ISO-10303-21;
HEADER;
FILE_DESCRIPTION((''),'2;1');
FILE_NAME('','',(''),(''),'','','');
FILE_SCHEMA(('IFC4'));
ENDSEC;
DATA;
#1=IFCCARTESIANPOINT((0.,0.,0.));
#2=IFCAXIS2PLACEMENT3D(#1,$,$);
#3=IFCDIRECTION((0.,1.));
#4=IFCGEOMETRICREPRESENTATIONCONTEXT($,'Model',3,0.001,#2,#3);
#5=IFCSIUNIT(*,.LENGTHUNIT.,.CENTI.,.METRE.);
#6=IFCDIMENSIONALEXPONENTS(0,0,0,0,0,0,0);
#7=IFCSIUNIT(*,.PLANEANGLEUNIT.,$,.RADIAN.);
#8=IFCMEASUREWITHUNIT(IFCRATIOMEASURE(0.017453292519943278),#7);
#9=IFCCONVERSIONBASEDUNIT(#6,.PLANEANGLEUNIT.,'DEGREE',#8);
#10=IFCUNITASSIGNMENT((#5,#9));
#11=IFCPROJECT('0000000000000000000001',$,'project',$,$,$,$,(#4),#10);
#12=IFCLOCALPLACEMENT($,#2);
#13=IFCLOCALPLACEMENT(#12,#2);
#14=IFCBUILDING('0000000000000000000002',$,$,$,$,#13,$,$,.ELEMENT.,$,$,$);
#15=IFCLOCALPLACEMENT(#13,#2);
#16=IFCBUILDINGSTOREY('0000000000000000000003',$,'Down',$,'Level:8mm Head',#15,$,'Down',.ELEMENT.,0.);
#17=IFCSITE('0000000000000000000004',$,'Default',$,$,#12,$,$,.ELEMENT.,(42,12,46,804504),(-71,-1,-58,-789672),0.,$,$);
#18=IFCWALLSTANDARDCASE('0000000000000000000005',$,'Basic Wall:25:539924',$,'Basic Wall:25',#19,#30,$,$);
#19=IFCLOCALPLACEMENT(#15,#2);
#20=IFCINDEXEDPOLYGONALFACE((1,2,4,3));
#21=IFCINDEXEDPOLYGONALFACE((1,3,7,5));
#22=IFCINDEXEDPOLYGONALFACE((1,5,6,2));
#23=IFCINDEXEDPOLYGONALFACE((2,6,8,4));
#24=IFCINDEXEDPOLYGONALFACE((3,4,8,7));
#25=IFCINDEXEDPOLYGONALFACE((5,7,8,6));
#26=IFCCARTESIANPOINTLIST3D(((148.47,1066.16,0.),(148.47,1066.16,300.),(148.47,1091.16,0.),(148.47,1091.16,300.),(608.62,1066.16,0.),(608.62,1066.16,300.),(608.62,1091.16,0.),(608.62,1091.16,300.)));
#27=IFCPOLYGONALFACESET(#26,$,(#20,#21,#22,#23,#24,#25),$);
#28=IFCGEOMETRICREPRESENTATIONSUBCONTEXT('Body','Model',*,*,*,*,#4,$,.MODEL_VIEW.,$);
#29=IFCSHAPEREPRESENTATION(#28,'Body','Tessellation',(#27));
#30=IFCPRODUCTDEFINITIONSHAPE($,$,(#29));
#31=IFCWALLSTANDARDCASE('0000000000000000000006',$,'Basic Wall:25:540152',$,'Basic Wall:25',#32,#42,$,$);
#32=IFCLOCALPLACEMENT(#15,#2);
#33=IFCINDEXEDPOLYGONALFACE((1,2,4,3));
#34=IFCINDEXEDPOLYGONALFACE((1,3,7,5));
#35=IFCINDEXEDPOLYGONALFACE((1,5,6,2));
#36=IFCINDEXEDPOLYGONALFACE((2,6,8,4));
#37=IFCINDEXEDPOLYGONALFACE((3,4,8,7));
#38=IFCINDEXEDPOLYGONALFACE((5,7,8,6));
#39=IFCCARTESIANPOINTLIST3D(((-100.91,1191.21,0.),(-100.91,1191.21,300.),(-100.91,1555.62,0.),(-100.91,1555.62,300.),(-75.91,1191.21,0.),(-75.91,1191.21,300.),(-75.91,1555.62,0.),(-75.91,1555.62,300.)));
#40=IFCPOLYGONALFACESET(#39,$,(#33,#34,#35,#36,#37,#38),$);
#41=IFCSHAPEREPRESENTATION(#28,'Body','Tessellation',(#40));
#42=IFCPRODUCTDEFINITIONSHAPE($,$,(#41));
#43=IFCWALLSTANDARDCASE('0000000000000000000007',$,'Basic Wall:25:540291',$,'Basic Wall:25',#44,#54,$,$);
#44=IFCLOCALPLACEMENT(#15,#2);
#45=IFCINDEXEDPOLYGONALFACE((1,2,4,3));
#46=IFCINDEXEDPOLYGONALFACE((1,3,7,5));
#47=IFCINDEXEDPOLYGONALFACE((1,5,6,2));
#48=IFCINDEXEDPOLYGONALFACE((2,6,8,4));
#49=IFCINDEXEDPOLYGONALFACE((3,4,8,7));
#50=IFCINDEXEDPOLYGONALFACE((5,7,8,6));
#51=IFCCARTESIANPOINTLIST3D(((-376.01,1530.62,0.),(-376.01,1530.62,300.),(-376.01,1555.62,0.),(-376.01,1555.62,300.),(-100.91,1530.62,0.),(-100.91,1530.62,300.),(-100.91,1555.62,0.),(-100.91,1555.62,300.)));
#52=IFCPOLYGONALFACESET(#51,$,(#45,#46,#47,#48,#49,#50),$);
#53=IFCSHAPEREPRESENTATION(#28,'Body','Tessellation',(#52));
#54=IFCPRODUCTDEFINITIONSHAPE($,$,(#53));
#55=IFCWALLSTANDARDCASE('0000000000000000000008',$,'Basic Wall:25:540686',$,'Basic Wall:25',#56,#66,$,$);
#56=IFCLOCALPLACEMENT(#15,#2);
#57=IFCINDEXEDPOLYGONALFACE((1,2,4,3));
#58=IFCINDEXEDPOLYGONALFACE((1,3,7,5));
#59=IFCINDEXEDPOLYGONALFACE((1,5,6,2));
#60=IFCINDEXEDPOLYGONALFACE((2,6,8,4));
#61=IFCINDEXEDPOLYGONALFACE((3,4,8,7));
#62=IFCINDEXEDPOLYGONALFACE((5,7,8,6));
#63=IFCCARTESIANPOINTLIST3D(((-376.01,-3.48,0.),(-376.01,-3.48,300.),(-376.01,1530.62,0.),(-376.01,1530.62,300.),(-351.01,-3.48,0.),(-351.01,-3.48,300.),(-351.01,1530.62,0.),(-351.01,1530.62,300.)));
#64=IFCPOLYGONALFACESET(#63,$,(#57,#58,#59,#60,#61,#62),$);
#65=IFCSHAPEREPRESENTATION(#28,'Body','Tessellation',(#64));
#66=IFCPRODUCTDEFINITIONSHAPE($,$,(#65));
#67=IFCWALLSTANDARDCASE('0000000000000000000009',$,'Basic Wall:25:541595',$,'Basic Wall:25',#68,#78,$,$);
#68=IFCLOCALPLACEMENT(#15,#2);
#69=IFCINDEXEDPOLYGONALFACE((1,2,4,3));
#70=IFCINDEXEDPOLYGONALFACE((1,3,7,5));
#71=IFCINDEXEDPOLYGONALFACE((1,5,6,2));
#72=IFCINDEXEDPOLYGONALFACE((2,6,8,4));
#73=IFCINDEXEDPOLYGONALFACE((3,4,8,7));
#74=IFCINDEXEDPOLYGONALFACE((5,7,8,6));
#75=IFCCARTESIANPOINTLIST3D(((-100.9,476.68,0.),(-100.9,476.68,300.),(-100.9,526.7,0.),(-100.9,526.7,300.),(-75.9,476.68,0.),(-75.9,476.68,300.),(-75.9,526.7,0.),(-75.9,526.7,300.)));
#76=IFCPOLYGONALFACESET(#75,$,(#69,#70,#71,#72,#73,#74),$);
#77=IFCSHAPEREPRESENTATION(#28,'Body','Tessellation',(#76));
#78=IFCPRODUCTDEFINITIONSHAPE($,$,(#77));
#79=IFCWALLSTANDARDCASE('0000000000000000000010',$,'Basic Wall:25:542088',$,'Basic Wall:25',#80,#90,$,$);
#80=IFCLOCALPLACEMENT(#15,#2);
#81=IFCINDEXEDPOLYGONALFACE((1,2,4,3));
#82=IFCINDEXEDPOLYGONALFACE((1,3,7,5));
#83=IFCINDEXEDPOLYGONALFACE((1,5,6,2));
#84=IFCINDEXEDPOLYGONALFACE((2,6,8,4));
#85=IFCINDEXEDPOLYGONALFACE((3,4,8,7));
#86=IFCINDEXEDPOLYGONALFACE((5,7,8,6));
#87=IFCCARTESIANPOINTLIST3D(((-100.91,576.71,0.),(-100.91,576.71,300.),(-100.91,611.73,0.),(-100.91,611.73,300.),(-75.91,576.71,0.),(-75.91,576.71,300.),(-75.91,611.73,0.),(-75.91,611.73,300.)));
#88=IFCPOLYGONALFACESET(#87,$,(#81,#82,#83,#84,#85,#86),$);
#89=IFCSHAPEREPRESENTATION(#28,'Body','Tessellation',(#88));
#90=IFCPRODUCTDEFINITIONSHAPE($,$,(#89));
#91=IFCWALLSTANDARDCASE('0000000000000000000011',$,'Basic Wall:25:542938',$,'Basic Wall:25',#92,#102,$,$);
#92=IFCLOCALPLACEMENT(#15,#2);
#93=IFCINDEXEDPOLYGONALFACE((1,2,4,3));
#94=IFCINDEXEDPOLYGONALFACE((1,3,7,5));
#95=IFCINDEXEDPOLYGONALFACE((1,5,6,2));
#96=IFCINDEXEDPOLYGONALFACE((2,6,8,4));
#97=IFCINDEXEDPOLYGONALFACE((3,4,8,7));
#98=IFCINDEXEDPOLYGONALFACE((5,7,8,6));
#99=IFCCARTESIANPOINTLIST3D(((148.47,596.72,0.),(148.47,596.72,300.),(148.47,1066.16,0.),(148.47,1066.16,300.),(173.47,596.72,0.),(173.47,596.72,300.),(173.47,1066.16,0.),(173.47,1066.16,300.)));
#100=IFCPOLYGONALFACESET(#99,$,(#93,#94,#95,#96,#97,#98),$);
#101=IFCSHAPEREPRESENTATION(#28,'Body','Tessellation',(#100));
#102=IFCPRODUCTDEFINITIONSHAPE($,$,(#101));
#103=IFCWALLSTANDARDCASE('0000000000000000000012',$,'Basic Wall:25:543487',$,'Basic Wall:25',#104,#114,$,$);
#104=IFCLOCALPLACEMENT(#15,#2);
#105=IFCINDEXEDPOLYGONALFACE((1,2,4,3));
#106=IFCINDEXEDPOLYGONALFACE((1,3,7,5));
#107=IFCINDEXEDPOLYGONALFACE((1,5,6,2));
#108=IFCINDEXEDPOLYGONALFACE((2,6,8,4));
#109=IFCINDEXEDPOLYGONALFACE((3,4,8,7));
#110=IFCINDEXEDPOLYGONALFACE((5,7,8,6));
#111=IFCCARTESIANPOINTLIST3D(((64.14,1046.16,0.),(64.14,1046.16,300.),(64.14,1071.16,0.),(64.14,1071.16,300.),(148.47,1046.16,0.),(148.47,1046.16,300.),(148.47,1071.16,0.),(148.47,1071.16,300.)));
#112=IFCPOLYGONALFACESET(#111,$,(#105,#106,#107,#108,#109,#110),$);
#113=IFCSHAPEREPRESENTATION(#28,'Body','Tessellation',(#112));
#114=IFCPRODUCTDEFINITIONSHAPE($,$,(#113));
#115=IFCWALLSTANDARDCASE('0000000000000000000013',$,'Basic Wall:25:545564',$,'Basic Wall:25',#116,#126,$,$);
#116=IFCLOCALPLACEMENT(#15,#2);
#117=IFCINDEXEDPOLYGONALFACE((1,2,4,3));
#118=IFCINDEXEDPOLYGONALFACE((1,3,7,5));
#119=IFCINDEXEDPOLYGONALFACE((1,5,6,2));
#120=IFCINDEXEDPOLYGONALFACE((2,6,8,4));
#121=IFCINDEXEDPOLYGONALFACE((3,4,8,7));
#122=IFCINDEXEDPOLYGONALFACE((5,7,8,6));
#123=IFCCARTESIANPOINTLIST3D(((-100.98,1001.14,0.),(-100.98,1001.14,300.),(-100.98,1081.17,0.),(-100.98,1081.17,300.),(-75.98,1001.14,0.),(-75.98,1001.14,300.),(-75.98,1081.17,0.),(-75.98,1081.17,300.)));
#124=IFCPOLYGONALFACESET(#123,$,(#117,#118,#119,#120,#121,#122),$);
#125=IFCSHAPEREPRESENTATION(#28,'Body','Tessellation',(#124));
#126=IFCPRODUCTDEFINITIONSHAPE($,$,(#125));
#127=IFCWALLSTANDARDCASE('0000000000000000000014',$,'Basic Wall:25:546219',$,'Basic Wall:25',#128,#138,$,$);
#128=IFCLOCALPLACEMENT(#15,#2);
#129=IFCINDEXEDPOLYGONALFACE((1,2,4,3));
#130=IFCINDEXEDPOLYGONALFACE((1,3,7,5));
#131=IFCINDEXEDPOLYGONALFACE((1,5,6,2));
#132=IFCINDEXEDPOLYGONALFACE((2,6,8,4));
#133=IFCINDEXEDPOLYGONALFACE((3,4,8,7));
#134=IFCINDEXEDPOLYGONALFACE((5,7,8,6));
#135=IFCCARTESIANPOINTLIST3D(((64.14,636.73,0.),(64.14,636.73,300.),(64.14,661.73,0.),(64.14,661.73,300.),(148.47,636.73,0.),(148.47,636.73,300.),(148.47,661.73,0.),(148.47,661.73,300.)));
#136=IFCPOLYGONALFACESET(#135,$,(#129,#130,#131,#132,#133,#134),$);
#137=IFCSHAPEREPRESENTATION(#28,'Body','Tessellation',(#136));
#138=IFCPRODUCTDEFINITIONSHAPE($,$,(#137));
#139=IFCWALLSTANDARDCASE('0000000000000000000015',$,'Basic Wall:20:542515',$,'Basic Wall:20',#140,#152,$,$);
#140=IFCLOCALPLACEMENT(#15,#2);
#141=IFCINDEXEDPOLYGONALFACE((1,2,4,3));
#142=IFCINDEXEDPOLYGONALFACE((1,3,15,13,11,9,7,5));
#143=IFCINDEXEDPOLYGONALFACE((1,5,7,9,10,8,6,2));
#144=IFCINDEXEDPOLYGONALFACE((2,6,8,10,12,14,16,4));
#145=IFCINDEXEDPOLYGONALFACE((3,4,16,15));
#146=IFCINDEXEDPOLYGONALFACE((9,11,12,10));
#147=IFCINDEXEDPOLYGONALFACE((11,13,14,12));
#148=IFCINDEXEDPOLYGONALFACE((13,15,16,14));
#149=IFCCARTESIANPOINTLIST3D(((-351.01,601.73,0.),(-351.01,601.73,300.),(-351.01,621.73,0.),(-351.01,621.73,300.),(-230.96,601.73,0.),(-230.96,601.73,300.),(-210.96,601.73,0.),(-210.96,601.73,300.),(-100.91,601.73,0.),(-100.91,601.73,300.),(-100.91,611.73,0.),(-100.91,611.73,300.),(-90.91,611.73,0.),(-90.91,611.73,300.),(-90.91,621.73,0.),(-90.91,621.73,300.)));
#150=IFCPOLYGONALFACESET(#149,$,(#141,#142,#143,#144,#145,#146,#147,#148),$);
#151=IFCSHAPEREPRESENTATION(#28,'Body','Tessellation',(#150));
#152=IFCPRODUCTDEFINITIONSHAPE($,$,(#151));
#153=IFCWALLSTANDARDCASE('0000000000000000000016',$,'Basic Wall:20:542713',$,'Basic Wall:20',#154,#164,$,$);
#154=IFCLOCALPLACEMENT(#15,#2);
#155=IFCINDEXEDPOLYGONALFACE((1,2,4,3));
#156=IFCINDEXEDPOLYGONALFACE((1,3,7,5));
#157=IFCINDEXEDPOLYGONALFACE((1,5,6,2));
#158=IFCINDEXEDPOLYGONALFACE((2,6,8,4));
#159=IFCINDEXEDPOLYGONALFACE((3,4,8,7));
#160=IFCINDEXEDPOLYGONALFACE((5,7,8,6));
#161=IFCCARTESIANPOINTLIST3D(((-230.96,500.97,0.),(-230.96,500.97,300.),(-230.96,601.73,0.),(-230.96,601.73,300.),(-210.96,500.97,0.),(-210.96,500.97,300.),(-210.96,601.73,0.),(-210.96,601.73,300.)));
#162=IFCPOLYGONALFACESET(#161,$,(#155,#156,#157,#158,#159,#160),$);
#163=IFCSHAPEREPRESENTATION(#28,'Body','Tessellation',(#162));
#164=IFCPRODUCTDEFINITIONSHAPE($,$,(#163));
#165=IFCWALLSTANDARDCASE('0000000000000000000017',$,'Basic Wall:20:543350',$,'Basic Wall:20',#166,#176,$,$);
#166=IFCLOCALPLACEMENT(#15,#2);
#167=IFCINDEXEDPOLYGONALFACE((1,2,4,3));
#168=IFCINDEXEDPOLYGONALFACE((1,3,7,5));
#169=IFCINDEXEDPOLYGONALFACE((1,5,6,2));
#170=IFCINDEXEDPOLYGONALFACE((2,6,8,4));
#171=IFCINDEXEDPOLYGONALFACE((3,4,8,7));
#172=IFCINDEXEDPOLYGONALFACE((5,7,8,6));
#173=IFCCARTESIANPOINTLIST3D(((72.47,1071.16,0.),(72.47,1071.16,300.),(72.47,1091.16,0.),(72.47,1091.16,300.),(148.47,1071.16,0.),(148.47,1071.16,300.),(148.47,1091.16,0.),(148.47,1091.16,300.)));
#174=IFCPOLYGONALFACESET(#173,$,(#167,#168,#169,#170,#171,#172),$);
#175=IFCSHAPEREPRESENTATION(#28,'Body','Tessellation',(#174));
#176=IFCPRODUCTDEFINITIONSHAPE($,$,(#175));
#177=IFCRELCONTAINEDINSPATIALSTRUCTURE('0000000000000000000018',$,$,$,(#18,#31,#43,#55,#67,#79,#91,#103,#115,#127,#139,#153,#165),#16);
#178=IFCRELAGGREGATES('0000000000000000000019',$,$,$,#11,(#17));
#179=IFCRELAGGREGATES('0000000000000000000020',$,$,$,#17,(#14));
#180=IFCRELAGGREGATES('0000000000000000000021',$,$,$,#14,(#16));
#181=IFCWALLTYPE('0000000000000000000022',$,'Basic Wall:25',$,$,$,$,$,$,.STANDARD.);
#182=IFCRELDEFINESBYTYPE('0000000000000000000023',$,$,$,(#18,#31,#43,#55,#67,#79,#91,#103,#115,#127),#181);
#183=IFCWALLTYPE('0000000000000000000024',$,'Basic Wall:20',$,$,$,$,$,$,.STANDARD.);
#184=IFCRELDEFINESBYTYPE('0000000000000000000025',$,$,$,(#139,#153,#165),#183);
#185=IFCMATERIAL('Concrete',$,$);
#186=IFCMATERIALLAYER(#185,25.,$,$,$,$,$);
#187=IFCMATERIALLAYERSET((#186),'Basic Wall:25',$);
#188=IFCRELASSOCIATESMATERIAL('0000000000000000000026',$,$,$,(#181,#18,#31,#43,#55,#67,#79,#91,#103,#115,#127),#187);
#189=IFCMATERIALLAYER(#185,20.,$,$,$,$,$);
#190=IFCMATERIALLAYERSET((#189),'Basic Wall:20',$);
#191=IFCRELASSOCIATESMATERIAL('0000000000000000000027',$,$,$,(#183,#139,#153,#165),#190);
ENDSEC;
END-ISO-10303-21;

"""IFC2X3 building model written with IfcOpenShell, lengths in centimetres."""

from ifc_helpers import new_model, entity, si_unit, converted_unit, direction, frame, frame_2d, origin, place, context, subcontext, project, spatial, polyline, rectangle, outline, extrude, material, layer, layer_set, layer_usage, type_object, element, save


model = new_model("IFC2X3")

# Units and contexts
model_context = context("Model", 3, precision=0.001, world=origin(), true_north=direction((0.0, 1.0)))
body_context = subcontext(model_context, "Body", "Model", "MODEL_VIEW")
ifc_project = project(units=[si_unit("LENGTHUNIT", "METRE", prefix="CENTI"), converted_unit("PLANEANGLEUNIT", "DEGREE", entity("IfcRatioMeasure", 0.017453292519943278), si_unit("PLANEANGLEUNIT", "RADIAN"), dimensions=[0, 0, 0, 0, 0, 0, 0])], contexts=[model_context])

# Site, building, storey
site_placement = place(None, origin())
site = spatial("IfcSite", under=ifc_project, at=site_placement, Name="Default", CompositionType="ELEMENT", RefLatitude=(42, 12, 46, 804504), RefLongitude=(-71, -1, -58, -789672), RefElevation=0.0)
building_placement = place(site_placement, origin())
building = spatial("IfcBuilding", under=site, at=building_placement, CompositionType="ELEMENT")
storey_placement = place(building_placement, origin())
storey = spatial("IfcBuildingStorey", under=building, at=storey_placement, Name="Down", ObjectType="Level:8mm Head", LongName="Down", CompositionType="ELEMENT", Elevation=0.0)

# Walls
ifc_material = material(Name="Concrete")
ifc_layer_1 = layer(ifc_material, 25.0)
ifc_layer_set_1 = layer_set([ifc_layer_1], Name="Basic Wall:25")
ifc_layer_usage_1 = layer_usage(ifc_layer_set_1, "AXIS2", "POSITIVE", -12.5)
wall_type_1 = type_object("IfcWallType", Name="Basic Wall:25", PredefinedType="STANDARD", material=ifc_layer_set_1)
wall_1_placement = place(storey_placement, frame((608.62, 1078.66, 0.0), z_axis=(0.0, 0.0, 1.0), x_axis=(-1.0, 0.0, 0.0)))
element("IfcWallStandardCase", 1, at=wall_1_placement, inside=storey, type_object=wall_type_1, material=ifc_layer_usage_1, Name="Basic Wall:25:539924", ObjectType="Basic Wall:25", context=body_context, shape_type="SweptSolid", body=[
    extrude(rectangle(XDim=460.16, YDim=25.0, at=frame_2d((230.08, 0.0), x_axis=(-1.0, 0.0))), origin(), (0.0, 0.0, 1.0), 300.0),
])
ifc_layer_usage_2 = layer_usage(ifc_layer_set_1, "AXIS2", "NEGATIVE", 12.5)
wall_2_placement = place(storey_placement, frame((-88.41, 1191.21, 0.0), z_axis=(0.0, 0.0, 1.0), x_axis=(0.0, 1.0, 0.0)))
element("IfcWallStandardCase", 2, at=wall_2_placement, inside=storey, type_object=wall_type_1, material=ifc_layer_usage_2, Name="Basic Wall:25:540152", ObjectType="Basic Wall:25", context=body_context, shape_type="SweptSolid", body=[
    extrude(rectangle(XDim=364.41, YDim=25.0, at=frame_2d((182.2, 0.0), x_axis=(-1.0, 0.0))), origin(), (0.0, 0.0, 1.0), 300.0),
])
ifc_layer_usage_3 = layer_usage(ifc_layer_set_1, "AXIS2", "POSITIVE", -12.5)
wall_3_placement = place(storey_placement, frame((-100.91, 1543.12, 0.0), z_axis=(0.0, 0.0, 1.0), x_axis=(-1.0, 0.0, 0.0)))
element("IfcWallStandardCase", 3, at=wall_3_placement, inside=storey, type_object=wall_type_1, material=ifc_layer_usage_3, Name="Basic Wall:25:540291", ObjectType="Basic Wall:25", context=body_context, shape_type="SweptSolid", body=[
    extrude(rectangle(XDim=275.09, YDim=25.0, at=frame_2d((137.55, 0.0), x_axis=(-1.0, 0.0))), origin(), (0.0, 0.0, 1.0), 300.0),
])
ifc_layer_usage_4 = layer_usage(ifc_layer_set_1, "AXIS2", "POSITIVE", -12.5)
wall_4_placement = place(storey_placement, frame((-363.51, 1530.62, 0.0), z_axis=(0.0, 0.0, 1.0), x_axis=(0.0, -1.0, 0.0)))
element("IfcWallStandardCase", 4, at=wall_4_placement, inside=storey, type_object=wall_type_1, material=ifc_layer_usage_4, Name="Basic Wall:25:540686", ObjectType="Basic Wall:25", context=body_context, shape_type="SweptSolid", body=[
    extrude(rectangle(XDim=1534.1, YDim=25.0, at=frame_2d((767.05, 0.0), x_axis=(-1.0, 0.0))), origin(), (0.0, 0.0, 1.0), 300.0),
])
ifc_layer_usage_5 = layer_usage(ifc_layer_set_1, "AXIS2", "POSITIVE", -12.5)
wall_5_placement = place(storey_placement, frame((-88.4, 526.7, 0.0), z_axis=(0.0, 0.0, 1.0), x_axis=(0.0, -1.0, 0.0)))
element("IfcWallStandardCase", 5, at=wall_5_placement, inside=storey, type_object=wall_type_1, material=ifc_layer_usage_5, Name="Basic Wall:25:541595", ObjectType="Basic Wall:25", context=body_context, shape_type="SweptSolid", body=[
    extrude(rectangle(XDim=50.02, YDim=25.0, at=frame_2d((25.01, 0.0), x_axis=(-1.0, 0.0))), origin(), (0.0, 0.0, 1.0), 300.0),
])
ifc_layer_usage_6 = layer_usage(ifc_layer_set_1, "AXIS2", "NEGATIVE", 12.5)
wall_6_placement = place(storey_placement, frame((-88.41, 576.71, 0.0), z_axis=(0.0, 0.0, 1.0), x_axis=(0.0, 1.0, 0.0)))
element("IfcWallStandardCase", 6, at=wall_6_placement, inside=storey, type_object=wall_type_1, material=ifc_layer_usage_6, Name="Basic Wall:25:542088", ObjectType="Basic Wall:25", context=body_context, shape_type="SweptSolid", body=[
    extrude(rectangle(XDim=35.02, YDim=25.0, at=frame_2d((17.51, 0.0), x_axis=(-1.0, 0.0))), origin(), (0.0, 0.0, 1.0), 300.0),
])
ifc_layer_usage_7 = layer_usage(ifc_layer_set_1, "AXIS2", "POSITIVE", -12.5)
wall_7_placement = place(storey_placement, frame((160.97, 596.72, 0.0), z_axis=(0.0, 0.0, 1.0), x_axis=(0.0, 1.0, 0.0)))
element("IfcWallStandardCase", 7, at=wall_7_placement, inside=storey, type_object=wall_type_1, material=ifc_layer_usage_7, Name="Basic Wall:25:542938", ObjectType="Basic Wall:25", context=body_context, shape_type="SweptSolid", body=[
    extrude(rectangle(XDim=469.44, YDim=25.0, at=frame_2d((234.72, 0.0), x_axis=(-1.0, 0.0))), origin(), (0.0, 0.0, 1.0), 300.0),
])
ifc_layer_usage_8 = layer_usage(ifc_layer_set_1, "AXIS2", "POSITIVE", -12.5)
wall_8_placement = place(storey_placement, frame((64.14, 1058.66, 0.0)))
element("IfcWallStandardCase", 8, at=wall_8_placement, inside=storey, type_object=wall_type_1, material=ifc_layer_usage_8, Name="Basic Wall:25:543487", ObjectType="Basic Wall:25", context=body_context, shape_type="SweptSolid", body=[
    extrude(rectangle(XDim=84.32, YDim=25.0, at=frame_2d((42.16, 0.0), x_axis=(-1.0, 0.0))), origin(), (0.0, 0.0, 1.0), 300.0),
])
ifc_layer_usage_9 = layer_usage(ifc_layer_set_1, "AXIS2", "POSITIVE", -12.5)
wall_9_placement = place(storey_placement, frame((-88.48, 1081.17, 0.0), z_axis=(0.0, 0.0, 1.0), x_axis=(0.0, -1.0, 0.0)))
element("IfcWallStandardCase", 9, at=wall_9_placement, inside=storey, type_object=wall_type_1, material=ifc_layer_usage_9, Name="Basic Wall:25:545564", ObjectType="Basic Wall:25", context=body_context, shape_type="SweptSolid", body=[
    extrude(rectangle(XDim=80.03, YDim=25.0, at=frame_2d((40.01, 0.0), x_axis=(-1.0, 0.0))), origin(), (0.0, 0.0, 1.0), 300.0),
])
ifc_layer_usage_10 = layer_usage(ifc_layer_set_1, "AXIS2", "NEGATIVE", 12.5)
wall_10_placement = place(storey_placement, frame((148.47, 649.23, 0.0), z_axis=(0.0, 0.0, 1.0), x_axis=(-1.0, 0.0, 0.0)))
element("IfcWallStandardCase", 10, at=wall_10_placement, inside=storey, type_object=wall_type_1, material=ifc_layer_usage_10, Name="Basic Wall:25:546219", ObjectType="Basic Wall:25", context=body_context, shape_type="SweptSolid", body=[
    extrude(rectangle(XDim=84.32, YDim=25.0, at=frame_2d((42.16, 0.0), x_axis=(-1.0, 0.0))), origin(), (0.0, 0.0, 1.0), 300.0),
])
ifc_layer_2 = layer(ifc_material, 20.0)
ifc_layer_set_2 = layer_set([ifc_layer_2], Name="Basic Wall:20")
ifc_layer_usage_11 = layer_usage(ifc_layer_set_2, "AXIS2", "POSITIVE", -10.0)
wall_type_2 = type_object("IfcWallType", Name="Basic Wall:20", PredefinedType="STANDARD", material=ifc_layer_set_2)
wall_11_placement = place(storey_placement, frame((-90.91, 611.73, 0.0), z_axis=(0.0, 0.0, 1.0), x_axis=(-1.0, 0.0, 0.0)))
element("IfcWallStandardCase", 11, at=wall_11_placement, inside=storey, type_object=wall_type_2, material=ifc_layer_usage_11, Name="Basic Wall:20:542515", ObjectType="Basic Wall:20", context=body_context, shape_type="SweptSolid", body=[
    extrude(outline(polyline([(260.09, -10.0), (260.09, 10.0), (140.04, 10.0), (120.04, 10.0), (10.0, 10.0), (10.0, 0.0), (0.0, 0.0), (0.0, -10.0), (260.09, -10.0)])), origin(), (0.0, 0.0, 1.0), 300.0),
])
ifc_layer_usage_12 = layer_usage(ifc_layer_set_2, "AXIS2", "POSITIVE", -10.0)
wall_12_placement = place(storey_placement, frame((-220.96, 601.73, 0.0), z_axis=(0.0, 0.0, 1.0), x_axis=(0.0, -1.0, 0.0)))
element("IfcWallStandardCase", 12, at=wall_12_placement, inside=storey, type_object=wall_type_2, material=ifc_layer_usage_12, Name="Basic Wall:20:542713", ObjectType="Basic Wall:20", context=body_context, shape_type="SweptSolid", body=[
    extrude(rectangle(XDim=100.76, YDim=20.0, at=frame_2d((50.38, 0.0), x_axis=(-1.0, 0.0))), origin(), (0.0, 0.0, 1.0), 300.0),
])
ifc_layer_usage_13 = layer_usage(ifc_layer_set_2, "AXIS2", "POSITIVE", -10.0)
wall_13_placement = place(storey_placement, frame((148.47, 1081.16, 0.0), z_axis=(0.0, 0.0, 1.0), x_axis=(-1.0, 0.0, 0.0)))
element("IfcWallStandardCase", 13, at=wall_13_placement, inside=storey, type_object=wall_type_2, material=ifc_layer_usage_13, Name="Basic Wall:20:543350", ObjectType="Basic Wall:20", context=body_context, shape_type="SweptSolid", body=[
    extrude(rectangle(XDim=76.0, YDim=20.0, at=frame_2d((38.0, 0.0), x_axis=(-1.0, 0.0))), origin(), (0.0, 0.0, 1.0), 300.0),
])

save(model, "model.ifc")
